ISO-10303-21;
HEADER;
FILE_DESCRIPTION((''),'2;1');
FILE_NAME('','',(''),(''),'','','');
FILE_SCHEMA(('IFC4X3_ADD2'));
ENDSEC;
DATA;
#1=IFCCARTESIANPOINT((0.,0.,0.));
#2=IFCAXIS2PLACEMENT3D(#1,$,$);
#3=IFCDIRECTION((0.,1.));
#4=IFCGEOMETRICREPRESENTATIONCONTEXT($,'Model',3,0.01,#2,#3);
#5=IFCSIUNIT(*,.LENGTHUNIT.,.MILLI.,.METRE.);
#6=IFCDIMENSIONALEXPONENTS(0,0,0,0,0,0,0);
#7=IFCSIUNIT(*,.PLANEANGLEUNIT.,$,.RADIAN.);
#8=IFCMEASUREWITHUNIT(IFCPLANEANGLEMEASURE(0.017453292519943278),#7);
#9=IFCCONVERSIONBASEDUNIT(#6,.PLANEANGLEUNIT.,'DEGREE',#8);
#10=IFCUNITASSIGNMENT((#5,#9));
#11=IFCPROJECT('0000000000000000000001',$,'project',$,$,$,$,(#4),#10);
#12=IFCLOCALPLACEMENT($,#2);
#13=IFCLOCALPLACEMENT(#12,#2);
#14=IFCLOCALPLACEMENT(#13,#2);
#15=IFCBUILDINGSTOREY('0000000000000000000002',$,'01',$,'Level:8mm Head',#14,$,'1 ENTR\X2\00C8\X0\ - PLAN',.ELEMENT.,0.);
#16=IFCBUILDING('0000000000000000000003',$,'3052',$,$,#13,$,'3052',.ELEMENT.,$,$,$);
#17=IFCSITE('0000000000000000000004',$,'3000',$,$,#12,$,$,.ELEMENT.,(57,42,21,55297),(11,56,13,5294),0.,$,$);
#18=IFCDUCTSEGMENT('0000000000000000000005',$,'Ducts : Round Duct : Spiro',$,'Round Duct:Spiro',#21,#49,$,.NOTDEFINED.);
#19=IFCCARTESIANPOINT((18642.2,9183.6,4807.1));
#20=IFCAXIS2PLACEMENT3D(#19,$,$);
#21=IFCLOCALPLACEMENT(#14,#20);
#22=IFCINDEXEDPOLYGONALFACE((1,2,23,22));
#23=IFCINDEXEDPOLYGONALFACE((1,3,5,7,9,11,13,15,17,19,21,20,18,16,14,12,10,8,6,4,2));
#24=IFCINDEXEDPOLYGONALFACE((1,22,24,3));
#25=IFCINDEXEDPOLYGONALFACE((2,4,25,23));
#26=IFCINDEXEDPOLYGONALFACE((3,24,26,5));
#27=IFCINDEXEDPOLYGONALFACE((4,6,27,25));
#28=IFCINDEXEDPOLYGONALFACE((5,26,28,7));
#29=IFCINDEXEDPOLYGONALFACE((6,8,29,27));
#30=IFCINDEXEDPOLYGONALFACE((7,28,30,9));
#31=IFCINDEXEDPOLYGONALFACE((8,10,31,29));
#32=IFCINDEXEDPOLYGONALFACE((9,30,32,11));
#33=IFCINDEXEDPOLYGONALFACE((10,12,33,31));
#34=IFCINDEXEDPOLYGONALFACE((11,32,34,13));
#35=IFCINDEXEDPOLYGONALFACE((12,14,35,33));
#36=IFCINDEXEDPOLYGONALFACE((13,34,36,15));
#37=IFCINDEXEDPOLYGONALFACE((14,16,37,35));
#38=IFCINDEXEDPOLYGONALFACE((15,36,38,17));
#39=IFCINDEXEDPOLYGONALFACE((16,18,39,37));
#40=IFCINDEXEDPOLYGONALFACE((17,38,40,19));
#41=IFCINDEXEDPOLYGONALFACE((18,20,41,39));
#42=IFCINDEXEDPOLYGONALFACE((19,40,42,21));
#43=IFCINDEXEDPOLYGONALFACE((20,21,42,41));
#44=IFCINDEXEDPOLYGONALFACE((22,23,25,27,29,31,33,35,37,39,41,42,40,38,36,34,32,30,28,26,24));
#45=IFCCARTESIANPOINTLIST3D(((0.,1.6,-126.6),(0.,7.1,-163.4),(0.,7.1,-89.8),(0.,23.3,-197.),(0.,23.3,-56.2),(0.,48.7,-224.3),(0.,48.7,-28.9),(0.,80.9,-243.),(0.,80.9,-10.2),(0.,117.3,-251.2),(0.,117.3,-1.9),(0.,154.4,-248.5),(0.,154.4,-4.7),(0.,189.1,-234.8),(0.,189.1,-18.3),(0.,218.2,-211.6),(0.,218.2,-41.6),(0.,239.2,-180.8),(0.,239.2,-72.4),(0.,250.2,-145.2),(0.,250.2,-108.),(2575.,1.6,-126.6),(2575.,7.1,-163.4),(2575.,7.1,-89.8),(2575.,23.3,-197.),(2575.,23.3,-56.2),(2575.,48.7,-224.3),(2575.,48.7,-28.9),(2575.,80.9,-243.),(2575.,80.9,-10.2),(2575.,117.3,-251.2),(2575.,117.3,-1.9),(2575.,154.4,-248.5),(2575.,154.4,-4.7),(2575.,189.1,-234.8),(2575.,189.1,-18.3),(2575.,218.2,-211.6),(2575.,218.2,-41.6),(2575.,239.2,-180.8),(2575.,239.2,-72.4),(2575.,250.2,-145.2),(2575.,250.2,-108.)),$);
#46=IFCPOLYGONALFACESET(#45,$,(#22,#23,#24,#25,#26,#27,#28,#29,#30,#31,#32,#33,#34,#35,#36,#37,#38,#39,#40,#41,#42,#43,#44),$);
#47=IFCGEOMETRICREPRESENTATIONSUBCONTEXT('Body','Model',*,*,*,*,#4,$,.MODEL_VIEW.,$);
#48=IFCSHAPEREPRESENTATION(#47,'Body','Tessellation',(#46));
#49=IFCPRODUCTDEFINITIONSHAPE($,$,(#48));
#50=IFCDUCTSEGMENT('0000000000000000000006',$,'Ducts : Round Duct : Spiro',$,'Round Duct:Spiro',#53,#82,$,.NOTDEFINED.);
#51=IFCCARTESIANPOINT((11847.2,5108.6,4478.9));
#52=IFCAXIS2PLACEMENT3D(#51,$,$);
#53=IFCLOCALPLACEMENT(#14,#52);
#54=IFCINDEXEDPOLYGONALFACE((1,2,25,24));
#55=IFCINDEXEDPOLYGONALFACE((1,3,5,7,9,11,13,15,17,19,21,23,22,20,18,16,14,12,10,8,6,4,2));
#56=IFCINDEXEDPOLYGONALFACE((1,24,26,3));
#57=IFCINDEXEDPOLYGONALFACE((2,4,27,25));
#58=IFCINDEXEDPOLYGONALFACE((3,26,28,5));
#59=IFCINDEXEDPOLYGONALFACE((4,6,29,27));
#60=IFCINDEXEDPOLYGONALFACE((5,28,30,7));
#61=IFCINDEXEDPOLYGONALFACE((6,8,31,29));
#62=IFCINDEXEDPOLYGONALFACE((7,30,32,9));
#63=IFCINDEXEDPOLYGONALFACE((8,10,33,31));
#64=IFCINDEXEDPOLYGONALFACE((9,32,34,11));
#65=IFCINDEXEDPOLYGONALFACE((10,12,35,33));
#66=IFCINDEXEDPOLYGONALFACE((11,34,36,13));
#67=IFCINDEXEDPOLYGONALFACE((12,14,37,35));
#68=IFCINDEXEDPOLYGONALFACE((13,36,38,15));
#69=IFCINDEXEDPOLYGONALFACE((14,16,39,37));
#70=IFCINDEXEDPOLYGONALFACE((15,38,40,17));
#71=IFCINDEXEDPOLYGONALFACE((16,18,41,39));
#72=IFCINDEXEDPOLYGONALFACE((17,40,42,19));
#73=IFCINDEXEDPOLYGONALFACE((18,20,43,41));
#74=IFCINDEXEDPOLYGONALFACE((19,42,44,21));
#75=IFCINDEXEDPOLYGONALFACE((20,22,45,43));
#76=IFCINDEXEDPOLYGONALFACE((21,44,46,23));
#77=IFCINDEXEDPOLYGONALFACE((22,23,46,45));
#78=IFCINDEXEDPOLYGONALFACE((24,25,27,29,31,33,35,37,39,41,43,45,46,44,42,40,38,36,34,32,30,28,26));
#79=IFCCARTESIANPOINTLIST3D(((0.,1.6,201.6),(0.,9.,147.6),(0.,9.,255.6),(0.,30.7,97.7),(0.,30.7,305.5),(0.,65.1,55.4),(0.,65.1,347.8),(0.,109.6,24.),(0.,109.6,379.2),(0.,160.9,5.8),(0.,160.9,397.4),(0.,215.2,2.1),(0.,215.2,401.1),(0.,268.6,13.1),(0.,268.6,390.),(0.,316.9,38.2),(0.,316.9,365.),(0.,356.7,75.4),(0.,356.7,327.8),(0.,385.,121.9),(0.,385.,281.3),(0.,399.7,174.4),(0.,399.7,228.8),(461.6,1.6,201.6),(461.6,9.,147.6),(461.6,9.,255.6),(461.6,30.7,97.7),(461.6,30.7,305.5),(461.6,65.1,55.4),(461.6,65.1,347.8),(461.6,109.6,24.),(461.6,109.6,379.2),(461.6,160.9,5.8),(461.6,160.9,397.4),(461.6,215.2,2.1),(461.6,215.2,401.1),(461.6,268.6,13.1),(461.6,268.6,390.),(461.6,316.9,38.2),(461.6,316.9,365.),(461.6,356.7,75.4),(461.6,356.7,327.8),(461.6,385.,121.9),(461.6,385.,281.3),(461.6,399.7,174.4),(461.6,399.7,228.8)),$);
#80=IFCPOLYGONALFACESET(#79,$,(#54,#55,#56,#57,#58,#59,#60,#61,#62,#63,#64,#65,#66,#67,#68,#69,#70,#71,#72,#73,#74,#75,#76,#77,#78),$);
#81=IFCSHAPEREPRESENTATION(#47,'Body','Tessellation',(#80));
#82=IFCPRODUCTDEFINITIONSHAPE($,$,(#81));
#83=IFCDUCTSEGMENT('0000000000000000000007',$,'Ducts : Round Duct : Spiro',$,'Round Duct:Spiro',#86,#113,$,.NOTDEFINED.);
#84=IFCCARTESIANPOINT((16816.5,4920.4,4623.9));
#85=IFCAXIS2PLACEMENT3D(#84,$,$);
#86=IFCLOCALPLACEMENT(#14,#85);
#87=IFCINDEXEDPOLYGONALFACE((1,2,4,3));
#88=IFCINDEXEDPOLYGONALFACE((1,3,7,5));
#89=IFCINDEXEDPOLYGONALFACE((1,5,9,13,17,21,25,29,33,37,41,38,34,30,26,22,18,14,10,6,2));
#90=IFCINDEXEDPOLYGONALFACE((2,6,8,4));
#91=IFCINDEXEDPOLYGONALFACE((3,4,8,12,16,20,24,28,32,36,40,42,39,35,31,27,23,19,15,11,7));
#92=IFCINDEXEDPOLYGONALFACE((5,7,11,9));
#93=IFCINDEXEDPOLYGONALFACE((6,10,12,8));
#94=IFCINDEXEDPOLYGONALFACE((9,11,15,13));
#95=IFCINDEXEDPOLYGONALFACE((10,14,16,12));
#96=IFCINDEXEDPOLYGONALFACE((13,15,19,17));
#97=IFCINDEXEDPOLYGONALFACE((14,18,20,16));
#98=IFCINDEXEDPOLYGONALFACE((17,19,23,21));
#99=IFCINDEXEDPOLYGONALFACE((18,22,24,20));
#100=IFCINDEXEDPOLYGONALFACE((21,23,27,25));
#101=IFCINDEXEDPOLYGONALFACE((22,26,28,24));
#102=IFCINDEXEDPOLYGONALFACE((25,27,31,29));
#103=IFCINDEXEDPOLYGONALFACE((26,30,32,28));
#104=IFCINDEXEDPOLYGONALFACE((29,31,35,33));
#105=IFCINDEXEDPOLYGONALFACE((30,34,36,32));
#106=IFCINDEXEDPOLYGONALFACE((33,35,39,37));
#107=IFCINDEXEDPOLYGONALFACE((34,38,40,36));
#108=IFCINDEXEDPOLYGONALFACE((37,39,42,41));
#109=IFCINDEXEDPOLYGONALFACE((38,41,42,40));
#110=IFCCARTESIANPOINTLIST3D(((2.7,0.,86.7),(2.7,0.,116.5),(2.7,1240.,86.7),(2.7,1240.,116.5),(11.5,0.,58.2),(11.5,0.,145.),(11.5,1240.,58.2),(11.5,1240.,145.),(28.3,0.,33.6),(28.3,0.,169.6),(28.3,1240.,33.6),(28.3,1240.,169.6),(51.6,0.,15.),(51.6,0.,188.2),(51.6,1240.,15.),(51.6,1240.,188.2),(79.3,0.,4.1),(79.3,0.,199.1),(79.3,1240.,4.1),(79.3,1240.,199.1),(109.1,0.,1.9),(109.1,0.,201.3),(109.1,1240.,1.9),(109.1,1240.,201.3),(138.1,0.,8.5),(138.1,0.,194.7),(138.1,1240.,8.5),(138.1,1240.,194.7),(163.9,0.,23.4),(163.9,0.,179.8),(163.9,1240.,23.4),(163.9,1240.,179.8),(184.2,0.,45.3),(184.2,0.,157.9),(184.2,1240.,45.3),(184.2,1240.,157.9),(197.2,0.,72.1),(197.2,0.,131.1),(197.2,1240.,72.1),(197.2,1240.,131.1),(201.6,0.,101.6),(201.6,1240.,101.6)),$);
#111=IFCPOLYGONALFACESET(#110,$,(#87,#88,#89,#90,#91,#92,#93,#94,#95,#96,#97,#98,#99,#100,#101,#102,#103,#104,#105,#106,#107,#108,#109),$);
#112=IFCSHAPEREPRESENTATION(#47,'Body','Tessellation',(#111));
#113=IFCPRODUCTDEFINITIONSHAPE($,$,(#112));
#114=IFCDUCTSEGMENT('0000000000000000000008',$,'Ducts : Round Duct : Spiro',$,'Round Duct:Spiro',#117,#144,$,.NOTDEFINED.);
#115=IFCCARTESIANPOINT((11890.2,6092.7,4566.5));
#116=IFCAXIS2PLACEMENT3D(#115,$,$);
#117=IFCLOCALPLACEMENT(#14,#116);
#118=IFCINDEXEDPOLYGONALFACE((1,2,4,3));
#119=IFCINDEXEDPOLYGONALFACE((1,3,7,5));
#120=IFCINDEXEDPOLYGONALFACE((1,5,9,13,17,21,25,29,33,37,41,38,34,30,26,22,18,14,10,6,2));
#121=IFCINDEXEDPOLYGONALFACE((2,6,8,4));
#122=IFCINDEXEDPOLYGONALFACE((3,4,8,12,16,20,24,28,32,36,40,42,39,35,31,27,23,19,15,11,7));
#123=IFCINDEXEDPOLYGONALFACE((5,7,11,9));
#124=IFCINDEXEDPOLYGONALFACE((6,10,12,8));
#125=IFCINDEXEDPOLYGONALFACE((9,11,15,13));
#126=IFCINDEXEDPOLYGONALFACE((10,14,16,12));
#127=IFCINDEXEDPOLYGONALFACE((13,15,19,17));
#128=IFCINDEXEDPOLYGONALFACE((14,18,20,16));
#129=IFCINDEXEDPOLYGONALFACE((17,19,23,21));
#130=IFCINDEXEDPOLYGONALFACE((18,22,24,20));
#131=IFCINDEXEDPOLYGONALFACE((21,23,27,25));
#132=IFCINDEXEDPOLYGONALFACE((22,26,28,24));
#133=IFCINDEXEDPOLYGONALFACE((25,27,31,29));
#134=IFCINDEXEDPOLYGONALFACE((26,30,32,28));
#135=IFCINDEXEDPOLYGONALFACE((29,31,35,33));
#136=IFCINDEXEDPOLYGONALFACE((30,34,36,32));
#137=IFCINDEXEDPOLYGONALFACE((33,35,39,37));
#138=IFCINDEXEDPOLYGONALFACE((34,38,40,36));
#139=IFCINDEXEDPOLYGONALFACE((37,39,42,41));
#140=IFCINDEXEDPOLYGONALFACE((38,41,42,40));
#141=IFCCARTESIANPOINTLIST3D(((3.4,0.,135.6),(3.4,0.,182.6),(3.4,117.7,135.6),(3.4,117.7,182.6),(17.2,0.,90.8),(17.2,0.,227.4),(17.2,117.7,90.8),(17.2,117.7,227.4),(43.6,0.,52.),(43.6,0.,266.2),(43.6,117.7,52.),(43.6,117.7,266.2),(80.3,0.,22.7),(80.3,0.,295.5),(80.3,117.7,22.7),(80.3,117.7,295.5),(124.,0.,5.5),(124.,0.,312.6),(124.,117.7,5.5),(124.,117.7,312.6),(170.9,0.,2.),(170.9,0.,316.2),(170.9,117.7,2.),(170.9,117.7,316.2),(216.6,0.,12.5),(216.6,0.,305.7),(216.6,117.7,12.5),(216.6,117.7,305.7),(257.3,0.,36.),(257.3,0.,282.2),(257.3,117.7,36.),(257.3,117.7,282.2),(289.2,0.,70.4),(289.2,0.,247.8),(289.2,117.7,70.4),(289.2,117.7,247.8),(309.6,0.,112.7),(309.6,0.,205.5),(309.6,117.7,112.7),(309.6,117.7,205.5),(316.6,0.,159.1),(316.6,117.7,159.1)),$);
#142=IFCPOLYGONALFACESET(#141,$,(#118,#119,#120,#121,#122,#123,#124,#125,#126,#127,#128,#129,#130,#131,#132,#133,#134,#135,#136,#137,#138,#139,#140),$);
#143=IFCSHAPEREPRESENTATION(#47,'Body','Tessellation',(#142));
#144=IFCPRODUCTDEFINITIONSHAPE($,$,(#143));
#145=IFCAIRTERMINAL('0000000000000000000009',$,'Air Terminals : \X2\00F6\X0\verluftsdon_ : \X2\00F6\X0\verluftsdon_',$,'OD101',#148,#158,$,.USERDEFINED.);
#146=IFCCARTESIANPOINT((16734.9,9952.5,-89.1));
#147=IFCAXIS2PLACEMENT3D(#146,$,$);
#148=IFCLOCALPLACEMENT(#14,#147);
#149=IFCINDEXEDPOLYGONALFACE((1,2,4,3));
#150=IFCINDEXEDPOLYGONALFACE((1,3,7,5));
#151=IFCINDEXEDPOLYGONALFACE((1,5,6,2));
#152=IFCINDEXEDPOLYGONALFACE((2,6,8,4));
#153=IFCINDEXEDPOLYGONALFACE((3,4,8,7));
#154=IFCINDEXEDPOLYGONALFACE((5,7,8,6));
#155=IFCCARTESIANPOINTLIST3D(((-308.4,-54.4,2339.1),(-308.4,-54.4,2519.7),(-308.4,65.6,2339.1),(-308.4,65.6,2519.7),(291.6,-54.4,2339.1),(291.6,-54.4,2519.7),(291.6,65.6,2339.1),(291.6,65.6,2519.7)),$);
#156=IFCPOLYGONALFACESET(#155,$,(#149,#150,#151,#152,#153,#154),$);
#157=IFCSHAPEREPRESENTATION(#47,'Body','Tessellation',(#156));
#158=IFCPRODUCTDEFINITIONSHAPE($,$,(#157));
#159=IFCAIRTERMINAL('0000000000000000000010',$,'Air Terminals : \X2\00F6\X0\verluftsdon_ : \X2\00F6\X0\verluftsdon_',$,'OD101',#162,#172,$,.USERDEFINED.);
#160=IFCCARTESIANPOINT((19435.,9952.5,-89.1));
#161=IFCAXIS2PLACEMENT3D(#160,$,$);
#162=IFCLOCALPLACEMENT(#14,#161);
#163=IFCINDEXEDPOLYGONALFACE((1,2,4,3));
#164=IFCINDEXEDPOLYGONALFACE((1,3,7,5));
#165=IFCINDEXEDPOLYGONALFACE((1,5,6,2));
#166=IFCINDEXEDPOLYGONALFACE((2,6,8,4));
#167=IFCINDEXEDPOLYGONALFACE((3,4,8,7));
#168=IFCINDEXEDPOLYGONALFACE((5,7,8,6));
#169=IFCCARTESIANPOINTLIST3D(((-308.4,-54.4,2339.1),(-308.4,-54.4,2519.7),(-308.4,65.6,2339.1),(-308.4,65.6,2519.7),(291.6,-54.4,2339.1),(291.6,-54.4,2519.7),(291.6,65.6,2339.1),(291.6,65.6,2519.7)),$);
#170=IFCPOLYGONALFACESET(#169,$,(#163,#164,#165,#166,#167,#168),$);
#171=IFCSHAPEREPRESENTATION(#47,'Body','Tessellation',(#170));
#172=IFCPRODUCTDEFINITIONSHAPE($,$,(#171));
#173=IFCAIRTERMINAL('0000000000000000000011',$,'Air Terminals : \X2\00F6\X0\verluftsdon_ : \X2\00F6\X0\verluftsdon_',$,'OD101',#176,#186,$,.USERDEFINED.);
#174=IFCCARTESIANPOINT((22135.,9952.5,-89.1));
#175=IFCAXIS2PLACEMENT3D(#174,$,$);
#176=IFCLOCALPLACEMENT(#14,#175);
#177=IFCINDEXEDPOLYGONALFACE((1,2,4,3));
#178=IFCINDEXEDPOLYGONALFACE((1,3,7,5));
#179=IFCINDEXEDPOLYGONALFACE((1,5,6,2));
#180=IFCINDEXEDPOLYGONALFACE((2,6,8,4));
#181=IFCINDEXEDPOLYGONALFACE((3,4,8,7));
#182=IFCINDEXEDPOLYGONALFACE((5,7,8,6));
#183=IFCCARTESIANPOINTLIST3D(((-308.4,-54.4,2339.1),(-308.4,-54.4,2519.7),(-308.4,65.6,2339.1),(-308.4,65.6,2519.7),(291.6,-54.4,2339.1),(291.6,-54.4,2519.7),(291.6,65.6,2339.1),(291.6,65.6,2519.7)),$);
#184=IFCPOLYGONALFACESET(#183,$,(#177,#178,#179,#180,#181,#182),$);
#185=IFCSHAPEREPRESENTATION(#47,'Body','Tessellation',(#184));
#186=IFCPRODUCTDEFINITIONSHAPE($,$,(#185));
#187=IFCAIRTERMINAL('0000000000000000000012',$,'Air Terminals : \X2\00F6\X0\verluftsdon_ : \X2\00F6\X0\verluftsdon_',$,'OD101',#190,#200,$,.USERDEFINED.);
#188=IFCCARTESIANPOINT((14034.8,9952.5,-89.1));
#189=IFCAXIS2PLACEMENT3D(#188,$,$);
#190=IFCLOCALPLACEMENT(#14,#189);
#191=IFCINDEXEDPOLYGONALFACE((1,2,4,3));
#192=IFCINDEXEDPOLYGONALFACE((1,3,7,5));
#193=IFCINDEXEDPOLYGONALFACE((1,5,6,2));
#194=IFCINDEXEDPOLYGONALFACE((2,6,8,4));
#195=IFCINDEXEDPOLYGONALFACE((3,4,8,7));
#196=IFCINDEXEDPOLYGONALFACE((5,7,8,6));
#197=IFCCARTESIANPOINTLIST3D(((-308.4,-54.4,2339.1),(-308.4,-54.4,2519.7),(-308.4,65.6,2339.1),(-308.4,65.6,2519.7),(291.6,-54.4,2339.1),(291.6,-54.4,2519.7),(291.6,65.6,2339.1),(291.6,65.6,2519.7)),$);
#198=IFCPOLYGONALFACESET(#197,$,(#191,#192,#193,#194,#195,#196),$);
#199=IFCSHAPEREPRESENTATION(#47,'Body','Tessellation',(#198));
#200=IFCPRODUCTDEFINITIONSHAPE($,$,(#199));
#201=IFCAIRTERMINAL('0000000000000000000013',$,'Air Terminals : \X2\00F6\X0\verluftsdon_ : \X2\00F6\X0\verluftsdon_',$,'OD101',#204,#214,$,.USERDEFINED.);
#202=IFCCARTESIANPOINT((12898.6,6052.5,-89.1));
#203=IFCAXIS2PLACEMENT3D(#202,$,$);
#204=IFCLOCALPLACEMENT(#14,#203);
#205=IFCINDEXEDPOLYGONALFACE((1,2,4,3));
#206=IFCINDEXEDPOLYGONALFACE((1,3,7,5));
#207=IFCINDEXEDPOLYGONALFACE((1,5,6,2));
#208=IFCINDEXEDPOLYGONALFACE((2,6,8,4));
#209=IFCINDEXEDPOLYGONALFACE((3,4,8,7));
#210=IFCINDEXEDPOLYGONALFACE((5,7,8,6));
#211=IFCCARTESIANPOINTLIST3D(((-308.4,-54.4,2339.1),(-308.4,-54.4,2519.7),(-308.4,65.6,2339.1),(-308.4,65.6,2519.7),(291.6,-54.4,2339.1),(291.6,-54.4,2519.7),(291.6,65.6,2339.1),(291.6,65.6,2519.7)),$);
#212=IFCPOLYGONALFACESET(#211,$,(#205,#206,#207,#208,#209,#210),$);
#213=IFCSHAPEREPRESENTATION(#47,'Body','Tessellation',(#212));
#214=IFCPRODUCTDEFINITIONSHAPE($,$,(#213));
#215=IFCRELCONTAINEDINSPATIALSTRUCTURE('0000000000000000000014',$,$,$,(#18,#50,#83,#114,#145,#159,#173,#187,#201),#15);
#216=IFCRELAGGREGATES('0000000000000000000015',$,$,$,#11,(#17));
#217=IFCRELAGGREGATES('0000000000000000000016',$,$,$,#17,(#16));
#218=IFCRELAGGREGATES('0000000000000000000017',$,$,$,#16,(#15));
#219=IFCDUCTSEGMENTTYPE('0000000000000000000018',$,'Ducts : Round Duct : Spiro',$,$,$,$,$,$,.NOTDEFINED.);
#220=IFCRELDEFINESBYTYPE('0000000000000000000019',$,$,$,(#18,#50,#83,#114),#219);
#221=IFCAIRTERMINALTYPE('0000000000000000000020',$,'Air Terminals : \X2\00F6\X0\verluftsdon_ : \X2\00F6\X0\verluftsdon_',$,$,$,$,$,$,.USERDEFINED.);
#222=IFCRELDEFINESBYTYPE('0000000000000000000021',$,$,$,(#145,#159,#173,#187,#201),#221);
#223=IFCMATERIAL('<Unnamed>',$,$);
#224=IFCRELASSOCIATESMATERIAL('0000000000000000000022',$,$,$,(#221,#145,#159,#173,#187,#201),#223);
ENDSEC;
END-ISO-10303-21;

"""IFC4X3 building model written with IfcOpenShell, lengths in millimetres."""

from ifc_helpers import new_model, entity, si_unit, converted_unit, direction, frame, frame_2d, origin, origin_2d_with_axis, place, context, subcontext, project, spatial, rectangle, circle, extrude, source, transform, mapped, material, type_object, type_shapes, element, save


model = new_model("IFC4X3")

# Units and contexts
model_context = context("Model", 3, precision=0.01, world=origin(), true_north=direction((0.0, 1.0)))
body_context = subcontext(model_context, "Body", "Model", "MODEL_VIEW")
ifc_project = project(units=[si_unit("LENGTHUNIT", "METRE", prefix="MILLI"), converted_unit("PLANEANGLEUNIT", "DEGREE", entity("IfcPlaneAngleMeasure", 0.017453292519943278), si_unit("PLANEANGLEUNIT", "RADIAN"), dimensions=[0, 0, 0, 0, 0, 0, 0])], contexts=[model_context])

# Site, building, storey
site_placement = place(None, origin())
site = spatial("IfcSite", under=ifc_project, at=site_placement, Name="3000", CompositionType="ELEMENT", RefLatitude=(57, 42, 21, 55297), RefLongitude=(11, 56, 13, 5294), RefElevation=0.0)
building_placement = place(site_placement, origin())
building = spatial("IfcBuilding", under=site, at=building_placement, Name="3052", LongName="3052", CompositionType="ELEMENT")
storey_placement = place(building_placement, origin())
storey = spatial("IfcBuildingStorey", under=building, at=storey_placement, Name="01", ObjectType="Level:8mm Head", LongName="1 ENTRÈ - PLAN", CompositionType="ELEMENT", Elevation=0.0)

# Duct segments
duct_segment_type = type_object("IfcDuctSegmentType", Name="Ducts : Round Duct : Spiro", PredefinedType="NOTDEFINED")
duct_segment_1_placement = place(storey_placement, frame((18642.2, 9183.6, 4807.1)))
element("IfcDuctSegment", 1, at=duct_segment_1_placement, inside=storey, type_object=duct_segment_type, Name="Ducts : Round Duct : Spiro", ObjectType="Round Duct:Spiro", PredefinedType="NOTDEFINED", context=body_context, shape_type="SweptSolid", body=[
    extrude(circle(Radius=125.0, at=frame_2d((0.0, 0.0), x_axis=(1.0, 0.0))), frame((0.0, 126.6, -126.6), z_axis=(1.0, 0.0, 0.0), x_axis=(0.0, -1.0, 0.0)), (0.0, 0.0, 1.0), 2575.0),
])
duct_segment_2_placement = place(storey_placement, frame((11847.2, 5108.6, 4478.9)))
element("IfcDuctSegment", 2, at=duct_segment_2_placement, inside=storey, type_object=duct_segment_type, Name="Ducts : Round Duct : Spiro", ObjectType="Round Duct:Spiro", PredefinedType="NOTDEFINED", context=body_context, shape_type="SweptSolid", body=[
    extrude(circle(Radius=200.0, at=frame_2d((0.0, 0.0), x_axis=(1.0, 0.0))), frame((0.0, 201.6, 201.6), z_axis=(1.0, 0.0, 0.0), x_axis=(0.0, -1.0, 0.0)), (0.0, 0.0, 1.0), 461.6),
])
duct_segment_3_placement = place(storey_placement, frame((16816.5, 4920.4, 4623.9)))
element("IfcDuctSegment", 3, at=duct_segment_3_placement, inside=storey, type_object=duct_segment_type, Name="Ducts : Round Duct : Spiro", ObjectType="Round Duct:Spiro", PredefinedType="NOTDEFINED", context=body_context, shape_type="SweptSolid", body=[
    extrude(circle(Radius=100.0, at=origin_2d_with_axis()), frame((101.6, 0.0, 101.6), z_axis=(0.0, 1.0, 0.0), x_axis=(1.0, 0.0, 0.0)), (0.0, 0.0, 1.0), 1240.0),
])
duct_segment_4_placement = place(storey_placement, frame((11890.2, 6092.7, 4566.5)))
element("IfcDuctSegment", 4, at=duct_segment_4_placement, inside=storey, type_object=duct_segment_type, Name="Ducts : Round Duct : Spiro", ObjectType="Round Duct:Spiro", PredefinedType="NOTDEFINED", context=body_context, shape_type="SweptSolid", body=[
    extrude(circle(Radius=157.5, at=origin_2d_with_axis()), frame((159.1, 0.0, 159.1), z_axis=(0.0, 1.0, 0.0), x_axis=(1.0, 0.0, 0.0)), (0.0, 0.0, 1.0), 117.7),
])

# Air terminals
ifc_material_1 = material(Name="<Unnamed>")
air_terminal_type_1 = type_object("IfcAirTerminalType", Name="Air Terminals : överluftsdon_ : överluftsdon_", PredefinedType="USERDEFINED", material=ifc_material_1)
shared_shape_1 = source(origin(), body_context, "Body", "SweptSolid", [
    extrude(rectangle(XDim=600.0, YDim=120.0, at=origin_2d_with_axis()), frame((-8.4, 5.6, 2339.1), z_axis=(0.0, 0.0, 1.0), x_axis=(-1.0, 0.0, 0.0)), (0.0, 0.0, 1.0), 180.7),
])
type_shapes(air_terminal_type_1, [shared_shape_1])
for number, where, name in (
    (5, (16734.9, 9952.5, -89.1), "Air Terminals : överluftsdon_ : överluftsdon_"),
    (6, (19435.0, 9952.5, -89.1), "Air Terminals : överluftsdon_ : överluftsdon_"),
    (7, (22135.0, 9952.5, -89.1), "Air Terminals : överluftsdon_ : överluftsdon_"),
    (8, (14034.8, 9952.5, -89.1), "Air Terminals : överluftsdon_ : överluftsdon_"),
    (9, (12898.6, 6052.5, -89.1), "Air Terminals : överluftsdon_ : överluftsdon_"),
):
    element("IfcAirTerminal", number, at=place(storey_placement, frame(where)), inside=storey, type_object=air_terminal_type_1, material=ifc_material_1, Name=name, ObjectType="OD101", PredefinedType="USERDEFINED", context=body_context, shape_type="MappedRepresentation", body=[
        mapped(shared_shape_1, transform((0.0, 0.0, 0.0), scale=1.0)),
    ])

save(model, "model.ifc")
